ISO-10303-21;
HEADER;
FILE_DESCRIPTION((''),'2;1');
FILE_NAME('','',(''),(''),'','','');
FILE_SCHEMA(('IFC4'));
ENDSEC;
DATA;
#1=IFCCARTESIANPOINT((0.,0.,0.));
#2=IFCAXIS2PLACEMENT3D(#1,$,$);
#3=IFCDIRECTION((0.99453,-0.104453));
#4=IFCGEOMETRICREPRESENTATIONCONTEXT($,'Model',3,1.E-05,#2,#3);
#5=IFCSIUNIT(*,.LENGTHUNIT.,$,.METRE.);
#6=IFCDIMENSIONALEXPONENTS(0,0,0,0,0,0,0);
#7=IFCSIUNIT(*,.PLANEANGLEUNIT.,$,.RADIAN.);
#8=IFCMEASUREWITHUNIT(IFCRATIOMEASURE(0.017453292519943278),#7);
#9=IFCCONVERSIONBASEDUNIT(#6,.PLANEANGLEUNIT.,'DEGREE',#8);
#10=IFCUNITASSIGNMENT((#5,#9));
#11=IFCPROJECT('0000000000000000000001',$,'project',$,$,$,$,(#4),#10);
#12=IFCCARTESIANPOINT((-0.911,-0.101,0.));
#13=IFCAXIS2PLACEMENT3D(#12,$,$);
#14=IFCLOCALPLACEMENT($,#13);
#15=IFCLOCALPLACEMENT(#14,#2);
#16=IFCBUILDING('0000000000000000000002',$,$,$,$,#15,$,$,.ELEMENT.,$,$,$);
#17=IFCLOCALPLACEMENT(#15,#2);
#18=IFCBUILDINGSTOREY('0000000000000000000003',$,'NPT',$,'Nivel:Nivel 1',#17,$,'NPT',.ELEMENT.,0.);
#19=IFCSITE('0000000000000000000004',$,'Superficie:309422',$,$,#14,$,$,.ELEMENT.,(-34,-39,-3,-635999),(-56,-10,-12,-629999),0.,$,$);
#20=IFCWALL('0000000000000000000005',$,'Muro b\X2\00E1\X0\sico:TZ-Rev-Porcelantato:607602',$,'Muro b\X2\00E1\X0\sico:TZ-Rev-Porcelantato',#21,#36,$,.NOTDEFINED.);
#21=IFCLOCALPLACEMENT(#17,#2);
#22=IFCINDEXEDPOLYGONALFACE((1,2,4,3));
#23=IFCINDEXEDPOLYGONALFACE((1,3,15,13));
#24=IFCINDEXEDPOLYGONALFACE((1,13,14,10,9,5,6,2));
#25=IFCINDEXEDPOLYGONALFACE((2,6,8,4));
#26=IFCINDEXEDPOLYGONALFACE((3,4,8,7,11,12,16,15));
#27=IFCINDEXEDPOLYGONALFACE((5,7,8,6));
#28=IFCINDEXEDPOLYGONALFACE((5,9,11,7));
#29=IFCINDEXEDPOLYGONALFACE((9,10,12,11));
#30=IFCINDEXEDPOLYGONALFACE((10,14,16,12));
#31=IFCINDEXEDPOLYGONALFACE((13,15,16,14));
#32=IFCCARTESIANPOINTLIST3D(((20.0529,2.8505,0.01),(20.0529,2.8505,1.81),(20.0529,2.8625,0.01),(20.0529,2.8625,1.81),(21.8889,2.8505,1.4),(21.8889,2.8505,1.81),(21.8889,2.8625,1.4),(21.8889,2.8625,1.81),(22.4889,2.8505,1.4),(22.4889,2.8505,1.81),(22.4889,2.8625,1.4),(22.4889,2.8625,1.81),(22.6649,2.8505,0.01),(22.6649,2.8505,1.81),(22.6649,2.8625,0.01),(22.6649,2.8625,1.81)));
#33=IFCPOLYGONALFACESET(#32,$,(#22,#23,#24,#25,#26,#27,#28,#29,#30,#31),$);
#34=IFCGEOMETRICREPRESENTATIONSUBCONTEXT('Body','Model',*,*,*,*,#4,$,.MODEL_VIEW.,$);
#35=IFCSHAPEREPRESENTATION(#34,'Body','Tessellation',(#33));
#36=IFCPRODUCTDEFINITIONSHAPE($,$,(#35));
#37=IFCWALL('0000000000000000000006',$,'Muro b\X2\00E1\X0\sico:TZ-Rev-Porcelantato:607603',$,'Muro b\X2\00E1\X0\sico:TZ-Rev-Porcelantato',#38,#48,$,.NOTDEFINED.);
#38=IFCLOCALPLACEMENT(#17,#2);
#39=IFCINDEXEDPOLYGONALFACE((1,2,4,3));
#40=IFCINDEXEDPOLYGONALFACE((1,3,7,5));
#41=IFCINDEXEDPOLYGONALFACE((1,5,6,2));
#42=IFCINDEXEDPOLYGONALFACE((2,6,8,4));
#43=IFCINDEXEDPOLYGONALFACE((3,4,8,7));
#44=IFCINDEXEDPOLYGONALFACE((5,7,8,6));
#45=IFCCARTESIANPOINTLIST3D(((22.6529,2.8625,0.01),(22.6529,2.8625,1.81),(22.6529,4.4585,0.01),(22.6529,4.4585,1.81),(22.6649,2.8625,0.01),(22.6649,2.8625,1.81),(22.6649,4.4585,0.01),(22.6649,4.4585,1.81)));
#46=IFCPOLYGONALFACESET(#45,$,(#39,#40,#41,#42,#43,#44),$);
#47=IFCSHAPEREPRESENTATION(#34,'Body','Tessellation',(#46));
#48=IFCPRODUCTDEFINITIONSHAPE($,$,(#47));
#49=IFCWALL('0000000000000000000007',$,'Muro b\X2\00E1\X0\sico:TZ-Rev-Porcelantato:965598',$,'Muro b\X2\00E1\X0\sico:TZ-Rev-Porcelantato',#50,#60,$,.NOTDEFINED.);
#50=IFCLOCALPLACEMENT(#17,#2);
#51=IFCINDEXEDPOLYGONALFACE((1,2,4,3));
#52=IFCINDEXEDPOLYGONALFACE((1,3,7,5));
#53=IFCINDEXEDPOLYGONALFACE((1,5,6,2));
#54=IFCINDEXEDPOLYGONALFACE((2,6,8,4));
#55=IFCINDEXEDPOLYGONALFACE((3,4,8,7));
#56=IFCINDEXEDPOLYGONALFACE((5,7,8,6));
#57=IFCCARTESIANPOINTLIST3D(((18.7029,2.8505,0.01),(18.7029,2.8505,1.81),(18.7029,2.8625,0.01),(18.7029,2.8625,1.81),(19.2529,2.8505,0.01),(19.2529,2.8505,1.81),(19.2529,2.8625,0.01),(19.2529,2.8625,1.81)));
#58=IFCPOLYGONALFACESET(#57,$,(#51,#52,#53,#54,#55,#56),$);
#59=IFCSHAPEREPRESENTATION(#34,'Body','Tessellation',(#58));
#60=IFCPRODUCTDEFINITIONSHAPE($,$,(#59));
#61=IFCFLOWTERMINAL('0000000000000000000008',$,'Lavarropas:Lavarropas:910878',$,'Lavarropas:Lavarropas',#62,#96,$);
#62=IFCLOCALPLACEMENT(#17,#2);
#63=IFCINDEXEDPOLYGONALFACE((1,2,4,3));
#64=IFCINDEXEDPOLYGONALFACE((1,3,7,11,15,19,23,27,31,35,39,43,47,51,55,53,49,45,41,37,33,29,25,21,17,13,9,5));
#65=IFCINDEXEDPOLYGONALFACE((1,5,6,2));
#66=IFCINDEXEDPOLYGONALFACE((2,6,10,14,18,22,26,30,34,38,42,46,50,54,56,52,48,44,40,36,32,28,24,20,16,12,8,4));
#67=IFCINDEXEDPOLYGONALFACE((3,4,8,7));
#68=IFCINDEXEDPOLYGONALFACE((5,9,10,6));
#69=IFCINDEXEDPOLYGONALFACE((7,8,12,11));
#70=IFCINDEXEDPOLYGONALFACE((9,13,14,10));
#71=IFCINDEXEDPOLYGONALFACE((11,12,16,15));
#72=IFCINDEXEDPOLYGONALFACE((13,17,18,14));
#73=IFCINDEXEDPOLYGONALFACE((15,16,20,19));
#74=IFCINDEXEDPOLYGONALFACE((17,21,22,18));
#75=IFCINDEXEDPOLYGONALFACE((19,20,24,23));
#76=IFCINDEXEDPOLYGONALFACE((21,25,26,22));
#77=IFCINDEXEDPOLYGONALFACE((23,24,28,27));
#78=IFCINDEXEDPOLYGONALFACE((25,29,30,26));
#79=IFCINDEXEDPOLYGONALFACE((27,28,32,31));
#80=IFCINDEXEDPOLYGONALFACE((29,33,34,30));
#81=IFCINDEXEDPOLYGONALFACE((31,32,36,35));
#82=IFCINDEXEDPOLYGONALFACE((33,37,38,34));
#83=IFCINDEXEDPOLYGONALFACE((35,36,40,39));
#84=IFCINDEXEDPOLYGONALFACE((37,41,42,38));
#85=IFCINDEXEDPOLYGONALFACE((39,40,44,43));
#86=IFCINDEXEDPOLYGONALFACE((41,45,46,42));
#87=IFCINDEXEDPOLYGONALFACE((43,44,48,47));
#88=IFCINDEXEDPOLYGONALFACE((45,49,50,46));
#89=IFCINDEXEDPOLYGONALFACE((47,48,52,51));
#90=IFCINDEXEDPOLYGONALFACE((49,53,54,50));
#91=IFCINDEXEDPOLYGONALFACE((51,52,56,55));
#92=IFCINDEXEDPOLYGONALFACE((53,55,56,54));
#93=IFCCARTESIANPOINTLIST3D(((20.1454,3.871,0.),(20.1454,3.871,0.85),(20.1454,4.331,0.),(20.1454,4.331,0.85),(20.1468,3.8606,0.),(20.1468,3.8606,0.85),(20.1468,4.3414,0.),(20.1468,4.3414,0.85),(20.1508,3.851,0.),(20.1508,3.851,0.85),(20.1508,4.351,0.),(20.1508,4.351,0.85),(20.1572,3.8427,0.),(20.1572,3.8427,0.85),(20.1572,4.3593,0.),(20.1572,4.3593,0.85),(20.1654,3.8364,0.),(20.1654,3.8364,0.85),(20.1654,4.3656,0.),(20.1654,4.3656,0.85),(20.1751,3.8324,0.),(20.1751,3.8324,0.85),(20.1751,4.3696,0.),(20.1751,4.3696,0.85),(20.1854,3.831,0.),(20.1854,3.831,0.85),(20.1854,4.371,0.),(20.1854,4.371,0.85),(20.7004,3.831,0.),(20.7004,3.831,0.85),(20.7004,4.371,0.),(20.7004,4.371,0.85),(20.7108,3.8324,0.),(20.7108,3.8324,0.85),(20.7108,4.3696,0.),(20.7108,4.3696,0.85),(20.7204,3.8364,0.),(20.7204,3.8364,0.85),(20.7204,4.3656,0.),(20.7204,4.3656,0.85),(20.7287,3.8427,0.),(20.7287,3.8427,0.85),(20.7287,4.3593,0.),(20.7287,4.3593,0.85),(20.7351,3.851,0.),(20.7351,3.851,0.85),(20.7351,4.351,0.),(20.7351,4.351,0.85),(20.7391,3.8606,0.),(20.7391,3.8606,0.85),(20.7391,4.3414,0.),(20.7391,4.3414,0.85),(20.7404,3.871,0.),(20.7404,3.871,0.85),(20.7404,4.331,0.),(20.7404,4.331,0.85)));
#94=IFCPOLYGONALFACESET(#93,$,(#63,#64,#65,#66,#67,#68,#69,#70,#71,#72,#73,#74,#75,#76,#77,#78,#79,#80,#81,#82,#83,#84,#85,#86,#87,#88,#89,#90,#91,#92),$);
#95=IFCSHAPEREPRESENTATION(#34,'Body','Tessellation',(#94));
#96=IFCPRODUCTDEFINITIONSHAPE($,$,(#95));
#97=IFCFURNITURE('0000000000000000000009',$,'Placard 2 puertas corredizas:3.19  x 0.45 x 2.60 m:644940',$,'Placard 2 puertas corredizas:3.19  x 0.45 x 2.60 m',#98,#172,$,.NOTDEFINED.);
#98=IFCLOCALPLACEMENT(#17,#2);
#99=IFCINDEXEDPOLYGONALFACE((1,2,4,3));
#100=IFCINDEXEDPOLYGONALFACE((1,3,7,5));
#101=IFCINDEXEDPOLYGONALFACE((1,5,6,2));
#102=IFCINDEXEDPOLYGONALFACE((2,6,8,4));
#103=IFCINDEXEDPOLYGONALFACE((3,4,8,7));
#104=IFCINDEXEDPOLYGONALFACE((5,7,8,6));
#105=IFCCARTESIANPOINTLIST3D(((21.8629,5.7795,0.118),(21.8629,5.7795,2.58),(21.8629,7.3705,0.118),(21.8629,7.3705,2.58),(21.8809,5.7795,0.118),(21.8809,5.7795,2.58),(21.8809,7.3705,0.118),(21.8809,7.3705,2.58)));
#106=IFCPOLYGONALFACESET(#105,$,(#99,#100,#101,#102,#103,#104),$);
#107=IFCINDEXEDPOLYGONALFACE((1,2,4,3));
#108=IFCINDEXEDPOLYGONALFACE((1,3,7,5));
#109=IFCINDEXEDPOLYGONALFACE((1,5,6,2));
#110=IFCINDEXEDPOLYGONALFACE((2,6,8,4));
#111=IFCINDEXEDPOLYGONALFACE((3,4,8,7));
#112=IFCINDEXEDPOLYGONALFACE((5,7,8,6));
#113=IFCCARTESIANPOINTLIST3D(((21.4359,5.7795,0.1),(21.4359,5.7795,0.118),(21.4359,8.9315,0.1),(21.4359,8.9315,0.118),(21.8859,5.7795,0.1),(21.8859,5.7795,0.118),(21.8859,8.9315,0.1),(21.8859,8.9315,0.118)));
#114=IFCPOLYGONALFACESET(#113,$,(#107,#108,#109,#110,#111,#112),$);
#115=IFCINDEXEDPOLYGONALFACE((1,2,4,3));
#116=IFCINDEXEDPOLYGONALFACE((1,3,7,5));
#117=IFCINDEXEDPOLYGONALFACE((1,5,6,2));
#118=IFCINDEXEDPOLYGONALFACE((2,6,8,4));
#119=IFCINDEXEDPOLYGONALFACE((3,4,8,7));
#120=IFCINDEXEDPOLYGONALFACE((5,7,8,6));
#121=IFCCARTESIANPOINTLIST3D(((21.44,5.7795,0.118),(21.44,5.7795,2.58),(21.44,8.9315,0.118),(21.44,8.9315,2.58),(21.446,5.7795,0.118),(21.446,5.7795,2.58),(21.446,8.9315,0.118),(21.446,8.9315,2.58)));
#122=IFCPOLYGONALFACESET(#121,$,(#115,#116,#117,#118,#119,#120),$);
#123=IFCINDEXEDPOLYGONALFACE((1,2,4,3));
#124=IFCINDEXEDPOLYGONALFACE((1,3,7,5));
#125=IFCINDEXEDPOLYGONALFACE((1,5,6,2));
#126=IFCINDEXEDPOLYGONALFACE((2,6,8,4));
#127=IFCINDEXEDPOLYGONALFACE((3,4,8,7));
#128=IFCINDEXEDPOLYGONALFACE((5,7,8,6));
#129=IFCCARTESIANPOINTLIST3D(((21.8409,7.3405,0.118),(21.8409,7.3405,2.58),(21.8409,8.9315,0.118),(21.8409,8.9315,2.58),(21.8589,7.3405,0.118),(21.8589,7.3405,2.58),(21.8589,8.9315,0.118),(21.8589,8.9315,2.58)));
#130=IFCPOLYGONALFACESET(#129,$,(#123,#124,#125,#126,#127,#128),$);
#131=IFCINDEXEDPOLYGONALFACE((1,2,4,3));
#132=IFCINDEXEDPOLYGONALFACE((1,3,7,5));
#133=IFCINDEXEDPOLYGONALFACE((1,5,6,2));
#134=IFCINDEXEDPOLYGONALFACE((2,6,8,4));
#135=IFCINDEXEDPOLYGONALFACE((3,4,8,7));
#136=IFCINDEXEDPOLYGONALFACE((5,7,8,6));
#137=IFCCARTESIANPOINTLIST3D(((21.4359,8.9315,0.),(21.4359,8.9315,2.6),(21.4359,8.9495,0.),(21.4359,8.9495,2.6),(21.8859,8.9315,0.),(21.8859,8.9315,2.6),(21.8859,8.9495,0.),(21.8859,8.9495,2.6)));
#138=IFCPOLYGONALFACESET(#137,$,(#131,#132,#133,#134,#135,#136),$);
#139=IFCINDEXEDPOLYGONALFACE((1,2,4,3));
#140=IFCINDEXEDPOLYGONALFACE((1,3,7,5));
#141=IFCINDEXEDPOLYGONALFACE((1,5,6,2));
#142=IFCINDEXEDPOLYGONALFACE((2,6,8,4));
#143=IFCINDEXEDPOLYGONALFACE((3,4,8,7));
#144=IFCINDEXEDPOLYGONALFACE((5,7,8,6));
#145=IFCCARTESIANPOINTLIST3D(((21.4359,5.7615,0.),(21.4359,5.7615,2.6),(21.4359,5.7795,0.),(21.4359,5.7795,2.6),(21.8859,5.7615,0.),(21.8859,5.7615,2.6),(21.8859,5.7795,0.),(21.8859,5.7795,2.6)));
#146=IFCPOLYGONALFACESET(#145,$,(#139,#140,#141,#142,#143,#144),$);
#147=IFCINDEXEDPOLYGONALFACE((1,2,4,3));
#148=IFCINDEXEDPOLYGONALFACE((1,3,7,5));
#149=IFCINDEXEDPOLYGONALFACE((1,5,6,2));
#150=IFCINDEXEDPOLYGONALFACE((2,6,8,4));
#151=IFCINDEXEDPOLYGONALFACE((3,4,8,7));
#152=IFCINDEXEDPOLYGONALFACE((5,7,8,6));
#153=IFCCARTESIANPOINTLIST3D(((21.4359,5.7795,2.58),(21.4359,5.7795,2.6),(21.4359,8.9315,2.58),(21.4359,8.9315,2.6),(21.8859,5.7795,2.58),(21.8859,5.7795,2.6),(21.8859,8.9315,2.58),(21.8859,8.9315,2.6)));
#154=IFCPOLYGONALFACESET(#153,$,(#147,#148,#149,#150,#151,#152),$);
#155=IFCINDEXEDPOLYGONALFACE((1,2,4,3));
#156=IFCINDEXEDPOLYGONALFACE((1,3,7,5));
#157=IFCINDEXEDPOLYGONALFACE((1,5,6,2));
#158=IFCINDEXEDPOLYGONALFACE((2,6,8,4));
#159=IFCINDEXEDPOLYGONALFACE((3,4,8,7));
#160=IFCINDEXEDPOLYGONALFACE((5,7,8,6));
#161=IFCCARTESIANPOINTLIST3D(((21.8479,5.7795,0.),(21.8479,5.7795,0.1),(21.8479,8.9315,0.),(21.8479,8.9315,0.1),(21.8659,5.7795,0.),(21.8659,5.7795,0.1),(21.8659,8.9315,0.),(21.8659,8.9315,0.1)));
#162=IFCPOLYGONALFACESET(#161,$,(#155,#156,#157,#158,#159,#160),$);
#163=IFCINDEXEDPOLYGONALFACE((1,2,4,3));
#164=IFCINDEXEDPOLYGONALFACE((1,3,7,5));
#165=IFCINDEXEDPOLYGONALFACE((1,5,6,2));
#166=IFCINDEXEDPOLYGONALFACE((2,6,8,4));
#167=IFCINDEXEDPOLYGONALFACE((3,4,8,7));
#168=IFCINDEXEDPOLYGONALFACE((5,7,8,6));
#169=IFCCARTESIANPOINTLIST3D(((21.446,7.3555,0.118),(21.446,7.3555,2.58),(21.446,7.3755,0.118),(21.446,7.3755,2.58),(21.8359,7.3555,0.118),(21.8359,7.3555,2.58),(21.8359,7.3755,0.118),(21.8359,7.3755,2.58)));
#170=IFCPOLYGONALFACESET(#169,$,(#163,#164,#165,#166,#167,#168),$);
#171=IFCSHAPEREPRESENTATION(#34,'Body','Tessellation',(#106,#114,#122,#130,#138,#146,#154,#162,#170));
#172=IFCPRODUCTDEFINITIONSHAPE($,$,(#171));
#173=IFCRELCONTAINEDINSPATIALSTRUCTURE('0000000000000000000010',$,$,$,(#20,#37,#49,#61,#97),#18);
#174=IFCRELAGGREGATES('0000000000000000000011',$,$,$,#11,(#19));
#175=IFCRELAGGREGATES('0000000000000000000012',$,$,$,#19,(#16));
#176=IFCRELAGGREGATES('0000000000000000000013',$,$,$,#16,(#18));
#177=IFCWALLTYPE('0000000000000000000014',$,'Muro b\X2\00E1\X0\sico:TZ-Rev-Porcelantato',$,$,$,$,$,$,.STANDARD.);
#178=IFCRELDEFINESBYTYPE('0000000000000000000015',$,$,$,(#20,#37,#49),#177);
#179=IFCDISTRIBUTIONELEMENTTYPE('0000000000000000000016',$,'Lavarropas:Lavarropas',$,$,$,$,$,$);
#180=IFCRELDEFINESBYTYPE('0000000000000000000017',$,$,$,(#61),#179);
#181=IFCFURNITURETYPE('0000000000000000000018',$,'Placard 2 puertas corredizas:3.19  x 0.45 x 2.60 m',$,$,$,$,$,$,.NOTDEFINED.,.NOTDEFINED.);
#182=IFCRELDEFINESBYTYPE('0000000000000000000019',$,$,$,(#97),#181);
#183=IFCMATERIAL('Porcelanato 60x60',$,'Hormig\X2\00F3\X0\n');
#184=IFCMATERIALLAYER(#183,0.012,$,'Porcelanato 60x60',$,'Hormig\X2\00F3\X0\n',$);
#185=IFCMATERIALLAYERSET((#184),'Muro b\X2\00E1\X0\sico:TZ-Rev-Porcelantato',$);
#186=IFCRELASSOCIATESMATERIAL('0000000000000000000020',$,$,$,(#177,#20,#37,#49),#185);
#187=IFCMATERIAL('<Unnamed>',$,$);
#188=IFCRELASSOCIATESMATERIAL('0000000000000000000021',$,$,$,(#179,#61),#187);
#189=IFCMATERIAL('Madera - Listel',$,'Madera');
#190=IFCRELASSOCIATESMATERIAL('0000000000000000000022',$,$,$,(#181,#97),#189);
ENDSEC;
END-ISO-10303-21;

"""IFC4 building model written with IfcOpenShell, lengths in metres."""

from ifc_helpers import new_model, entity, si_unit, converted_unit, direction, frame, frame_2d, origin, origin_2d_with_axis, place, context, subcontext, project, spatial, polyline, circle_curve, parameter, trimmed, segment, composite_curve, rectangle, outline, extrude, source, transform, mapped, material, layer, layer_set, layer_usage, type_object, type_shapes, element, save


model = new_model("IFC4")

# Units and contexts
model_context = context("Model", 3, precision=1e-05, world=origin(), true_north=direction((0.99453, -0.104453)))
body_context = subcontext(model_context, "Body", "Model", "MODEL_VIEW")
ifc_project = project(units=[si_unit("LENGTHUNIT", "METRE"), converted_unit("PLANEANGLEUNIT", "DEGREE", entity("IfcRatioMeasure", 0.017453292519943278), si_unit("PLANEANGLEUNIT", "RADIAN"), dimensions=[0, 0, 0, 0, 0, 0, 0])], contexts=[model_context])

# Site, building, storey
site_placement = place(None, frame((-0.911, -0.101, 0.0)))
site = spatial("IfcSite", under=ifc_project, at=site_placement, Name="Superficie:309422", CompositionType="ELEMENT", RefLatitude=(-34, -39, -3, -635999), RefLongitude=(-56, -10, -12, -629999), RefElevation=0.0)
building_placement = place(site_placement, origin())
building = spatial("IfcBuilding", under=site, at=building_placement, CompositionType="ELEMENT")
storey_placement = place(building_placement, origin())
storey = spatial("IfcBuildingStorey", under=building, at=storey_placement, Name="NPT", ObjectType="Nivel:Nivel 1", LongName="NPT", CompositionType="ELEMENT", Elevation=0.0)

# Wall, opening
ifc_material_1 = material(Name="Porcelanato 60x60", Category="Hormigón")
ifc_layer_1 = layer(ifc_material_1, 0.012, Name="Porcelanato 60x60", Category="Hormigón")
ifc_layer_set_1 = layer_set([ifc_layer_1], Name="Muro básico:TZ-Rev-Porcelantato")
ifc_layer_usage_1 = layer_usage(ifc_layer_set_1, "AXIS2", "NEGATIVE", 0.006)
wall_type_1 = type_object("IfcWallType", Name="Muro básico:TZ-Rev-Porcelantato", PredefinedType="STANDARD", material=ifc_layer_set_1)
wall_1_placement = place(storey_placement, frame((22.6649, 2.8565, 0.01), z_axis=(0.0, 0.0, 1.0), x_axis=(-1.0, 0.0, 0.0)))
wall_1 = element("IfcWall", 1, at=wall_1_placement, inside=storey, type_object=wall_type_1, material=ifc_layer_usage_1, Name="Muro básico:TZ-Rev-Porcelantato:607602", ObjectType="Muro básico:TZ-Rev-Porcelantato", PredefinedType="NOTDEFINED", context=body_context, shape_type="SweptSolid", body=[
    extrude(rectangle(XDim=2.612, YDim=0.012, at=frame_2d((1.306, 0.0), x_axis=(-1.0, 0.0))), origin(), (0.0, 0.0, 1.0), 1.8),
])
opening_1_placement = place(wall_1_placement, frame((0.776, 1.5425, 1.39)))
element("IfcOpeningElement", 2, at=opening_1_placement, cuts=wall_1, PredefinedType="OPENING", context=body_context, shape_type="SweptSolid", body=[
    extrude(rectangle(XDim=0.6, YDim=0.6, at=frame_2d((0.0, 0.0), x_axis=(1.0, 0.0))), frame((-0.3, -3.048, 0.3), z_axis=(0.0, 1.0, 0.0), x_axis=(0.0, 0.0, 1.0)), (0.0, 0.0, 1.0), 3.048),
])

# Walls
ifc_layer_usage_2 = layer_usage(ifc_layer_set_1, "AXIS2", "NEGATIVE", 0.006)
wall_2_placement = place(storey_placement, frame((22.6589, 4.4585, 0.01), z_axis=(0.0, 0.0, 1.0), x_axis=(0.0, -1.0, 0.0)))
element("IfcWall", 3, at=wall_2_placement, inside=storey, type_object=wall_type_1, material=ifc_layer_usage_2, Name="Muro básico:TZ-Rev-Porcelantato:607603", ObjectType="Muro básico:TZ-Rev-Porcelantato", PredefinedType="NOTDEFINED", context=body_context, shape_type="SweptSolid", body=[
    extrude(rectangle(XDim=1.596, YDim=0.012, at=frame_2d((0.798, 0.0), x_axis=(-1.0, 0.0))), origin(), (0.0, 0.0, 1.0), 1.8),
])
ifc_layer_usage_3 = layer_usage(ifc_layer_set_1, "AXIS2", "NEGATIVE", 0.006)
wall_3_placement = place(storey_placement, frame((19.2529, 2.8565, 0.01), z_axis=(0.0, 0.0, 1.0), x_axis=(-1.0, 0.0, 0.0)))
element("IfcWall", 4, at=wall_3_placement, inside=storey, type_object=wall_type_1, material=ifc_layer_usage_3, Name="Muro básico:TZ-Rev-Porcelantato:965598", ObjectType="Muro básico:TZ-Rev-Porcelantato", PredefinedType="NOTDEFINED", context=body_context, shape_type="SweptSolid", body=[
    extrude(rectangle(XDim=0.55, YDim=0.012, at=frame_2d((0.275, 0.0), x_axis=(-1.0, 0.0))), origin(), (0.0, 0.0, 1.0), 1.8),
])

# Flow terminal
ifc_material_2 = material(Name="<Unnamed>")
distribution_element_type_1 = type_object("IfcDistributionElementType", Name="Lavarropas:Lavarropas", material=ifc_material_2)
shared_shape_1 = source(origin(), body_context, "Body", "SweptSolid", [
    extrude(outline(composite_curve([segment(polyline([(-0.2575, -0.27), (0.2575, -0.27)]), True, "CONTINUOUS"), segment(trimmed(circle_curve(frame_2d((0.2575, -0.23), x_axis=(1.0, 0.0)), 0.04), [parameter(270.0)], [parameter(360.0)], True, "PARAMETER"), True, "CONTINUOUS"), segment(polyline([(0.2975, -0.23), (0.2975, 0.23)]), True, "CONTINUOUS"), segment(trimmed(circle_curve(frame_2d((0.2575, 0.23), x_axis=(1.0, 0.0)), 0.04), [parameter(0.0)], [parameter(90.0)], True, "PARAMETER"), True, "CONTINUOUS"), segment(polyline([(0.2575, 0.27), (-0.2575, 0.27)]), True, "CONTINUOUS"), segment(trimmed(circle_curve(frame_2d((-0.2575, 0.23), x_axis=(1.0, 0.0)), 0.04), [parameter(90.0)], [parameter(180.0)], True, "PARAMETER"), True, "CONTINUOUS"), segment(polyline([(-0.2975, 0.23), (-0.2975, -0.23)]), True, "CONTINUOUS"), segment(trimmed(circle_curve(frame_2d((-0.2575, -0.23), x_axis=(1.0, 0.0)), 0.04), [parameter(180.0)], [parameter(270.0)], True, "PARAMETER"), True, "CONTINUOUS")], self_intersect=False)), origin(), (0.0, 0.0, 1.0), 0.85),
])
type_shapes(distribution_element_type_1, [shared_shape_1])
flow_terminal_1_placement = place(storey_placement, frame((20.4429, 4.101, 0.0), z_axis=(0.0, 0.0, 1.0), x_axis=(-1.0, 0.0, 0.0)))
element("IfcFlowTerminal", 5, at=flow_terminal_1_placement, inside=storey, type_object=distribution_element_type_1, material=ifc_material_2, Name="Lavarropas:Lavarropas:910878", ObjectType="Lavarropas:Lavarropas", context=body_context, shape_type="MappedRepresentation", body=[
    mapped(shared_shape_1, transform((0.0, 0.0, 0.0), scale=1.0)),
])

# Furniture
ifc_material_3 = material(Name="Madera - Listel", Category="Madera")
furniture_type = type_object("IfcFurnitureType", Name="Placard 2 puertas corredizas:3.19  x 0.45 x 2.60 m", AssemblyPlace="NOTDEFINED", PredefinedType="NOTDEFINED", material=ifc_material_3)
shared_shape_2 = source(origin(), body_context, "Body", "SweptSolid", [
    extrude(rectangle(XDim=0.018, YDim=1.591, at=frame_2d((0.0, 0.0), x_axis=(1.0, 0.0))), frame((-0.7805, -0.161, 0.118), z_axis=(0.0, 0.0, 1.0), x_axis=(0.0, 1.0, 0.0)), (0.0, 0.0, 1.0), 2.462),
    extrude(rectangle(XDim=0.45, YDim=3.152, at=origin_2d_with_axis()), frame((0.0, 0.05, 0.1), z_axis=(0.0, 0.0, 1.0), x_axis=(0.0, 1.0, 0.0)), (0.0, 0.0, 1.0), 0.018),
    extrude(rectangle(XDim=3.152, YDim=0.006, at=frame_2d((0.0, 0.0), x_axis=(1.0, 0.0))), frame((0.0, 0.2679, 0.118), z_axis=(0.0, 0.0, 1.0), x_axis=(-1.0, 0.0, 0.0)), (0.0, 0.0, 1.0), 2.462),
    extrude(rectangle(XDim=0.018, YDim=1.591, at=origin_2d_with_axis()), frame((0.7805, -0.139, 0.118), z_axis=(0.0, 0.0, 1.0), x_axis=(0.0, 1.0, 0.0)), (0.0, 0.0, 1.0), 2.462),
    extrude(rectangle(XDim=0.45, YDim=0.018, at=frame_2d((0.0, 0.0), x_axis=(1.0, 0.0))), frame((1.585, 0.05, 0.0), z_axis=(0.0, 0.0, 1.0), x_axis=(0.0, -1.0, 0.0)), (0.0, 0.0, 1.0), 2.6),
    extrude(rectangle(XDim=0.018, YDim=0.45, at=frame_2d((0.0, 0.0), x_axis=(1.0, 0.0))), frame((-1.585, 0.05, 0.0), z_axis=(0.0, 0.0, 1.0), x_axis=(-1.0, 0.0, 0.0)), (0.0, 0.0, 1.0), 2.6),
    extrude(rectangle(XDim=0.45, YDim=3.152, at=origin_2d_with_axis()), frame((0.0, 0.05, 2.58), z_axis=(0.0, 0.0, 1.0), x_axis=(0.0, 1.0, 0.0)), (0.0, 0.0, 1.0), 0.02),
    extrude(rectangle(XDim=0.018, YDim=3.152, at=origin_2d_with_axis()), frame((0.0, -0.146, 0.0), z_axis=(0.0, 0.0, 1.0), x_axis=(0.0, 1.0, 0.0)), (0.0, 0.0, 1.0), 0.1),
    extrude(rectangle(XDim=0.02, YDim=0.3899, at=frame_2d((0.0, 0.0), x_axis=(1.0, 0.0))), frame((0.01, 0.0699, 0.118), z_axis=(0.0, 0.0, 1.0), x_axis=(-1.0, 0.0, 0.0)), (0.0, 0.0, 1.0), 2.462),
])
type_shapes(furniture_type, [shared_shape_2])
furniture_placement = place(storey_placement, frame((21.7109, 7.3555, 0.0), z_axis=(0.0, 0.0, 1.0), x_axis=(0.0, 1.0, 0.0)))
element("IfcFurniture", 6, at=furniture_placement, inside=storey, type_object=furniture_type, material=ifc_material_3, Name="Placard 2 puertas corredizas:3.19  x 0.45 x 2.60 m:644940", ObjectType="Placard 2 puertas corredizas:3.19  x 0.45 x 2.60 m", PredefinedType="NOTDEFINED", context=body_context, shape_type="MappedRepresentation", body=[
    mapped(shared_shape_2, transform((0.0, 0.0, 0.0), scale=1.0)),
])

save(model, "model.ifc")
